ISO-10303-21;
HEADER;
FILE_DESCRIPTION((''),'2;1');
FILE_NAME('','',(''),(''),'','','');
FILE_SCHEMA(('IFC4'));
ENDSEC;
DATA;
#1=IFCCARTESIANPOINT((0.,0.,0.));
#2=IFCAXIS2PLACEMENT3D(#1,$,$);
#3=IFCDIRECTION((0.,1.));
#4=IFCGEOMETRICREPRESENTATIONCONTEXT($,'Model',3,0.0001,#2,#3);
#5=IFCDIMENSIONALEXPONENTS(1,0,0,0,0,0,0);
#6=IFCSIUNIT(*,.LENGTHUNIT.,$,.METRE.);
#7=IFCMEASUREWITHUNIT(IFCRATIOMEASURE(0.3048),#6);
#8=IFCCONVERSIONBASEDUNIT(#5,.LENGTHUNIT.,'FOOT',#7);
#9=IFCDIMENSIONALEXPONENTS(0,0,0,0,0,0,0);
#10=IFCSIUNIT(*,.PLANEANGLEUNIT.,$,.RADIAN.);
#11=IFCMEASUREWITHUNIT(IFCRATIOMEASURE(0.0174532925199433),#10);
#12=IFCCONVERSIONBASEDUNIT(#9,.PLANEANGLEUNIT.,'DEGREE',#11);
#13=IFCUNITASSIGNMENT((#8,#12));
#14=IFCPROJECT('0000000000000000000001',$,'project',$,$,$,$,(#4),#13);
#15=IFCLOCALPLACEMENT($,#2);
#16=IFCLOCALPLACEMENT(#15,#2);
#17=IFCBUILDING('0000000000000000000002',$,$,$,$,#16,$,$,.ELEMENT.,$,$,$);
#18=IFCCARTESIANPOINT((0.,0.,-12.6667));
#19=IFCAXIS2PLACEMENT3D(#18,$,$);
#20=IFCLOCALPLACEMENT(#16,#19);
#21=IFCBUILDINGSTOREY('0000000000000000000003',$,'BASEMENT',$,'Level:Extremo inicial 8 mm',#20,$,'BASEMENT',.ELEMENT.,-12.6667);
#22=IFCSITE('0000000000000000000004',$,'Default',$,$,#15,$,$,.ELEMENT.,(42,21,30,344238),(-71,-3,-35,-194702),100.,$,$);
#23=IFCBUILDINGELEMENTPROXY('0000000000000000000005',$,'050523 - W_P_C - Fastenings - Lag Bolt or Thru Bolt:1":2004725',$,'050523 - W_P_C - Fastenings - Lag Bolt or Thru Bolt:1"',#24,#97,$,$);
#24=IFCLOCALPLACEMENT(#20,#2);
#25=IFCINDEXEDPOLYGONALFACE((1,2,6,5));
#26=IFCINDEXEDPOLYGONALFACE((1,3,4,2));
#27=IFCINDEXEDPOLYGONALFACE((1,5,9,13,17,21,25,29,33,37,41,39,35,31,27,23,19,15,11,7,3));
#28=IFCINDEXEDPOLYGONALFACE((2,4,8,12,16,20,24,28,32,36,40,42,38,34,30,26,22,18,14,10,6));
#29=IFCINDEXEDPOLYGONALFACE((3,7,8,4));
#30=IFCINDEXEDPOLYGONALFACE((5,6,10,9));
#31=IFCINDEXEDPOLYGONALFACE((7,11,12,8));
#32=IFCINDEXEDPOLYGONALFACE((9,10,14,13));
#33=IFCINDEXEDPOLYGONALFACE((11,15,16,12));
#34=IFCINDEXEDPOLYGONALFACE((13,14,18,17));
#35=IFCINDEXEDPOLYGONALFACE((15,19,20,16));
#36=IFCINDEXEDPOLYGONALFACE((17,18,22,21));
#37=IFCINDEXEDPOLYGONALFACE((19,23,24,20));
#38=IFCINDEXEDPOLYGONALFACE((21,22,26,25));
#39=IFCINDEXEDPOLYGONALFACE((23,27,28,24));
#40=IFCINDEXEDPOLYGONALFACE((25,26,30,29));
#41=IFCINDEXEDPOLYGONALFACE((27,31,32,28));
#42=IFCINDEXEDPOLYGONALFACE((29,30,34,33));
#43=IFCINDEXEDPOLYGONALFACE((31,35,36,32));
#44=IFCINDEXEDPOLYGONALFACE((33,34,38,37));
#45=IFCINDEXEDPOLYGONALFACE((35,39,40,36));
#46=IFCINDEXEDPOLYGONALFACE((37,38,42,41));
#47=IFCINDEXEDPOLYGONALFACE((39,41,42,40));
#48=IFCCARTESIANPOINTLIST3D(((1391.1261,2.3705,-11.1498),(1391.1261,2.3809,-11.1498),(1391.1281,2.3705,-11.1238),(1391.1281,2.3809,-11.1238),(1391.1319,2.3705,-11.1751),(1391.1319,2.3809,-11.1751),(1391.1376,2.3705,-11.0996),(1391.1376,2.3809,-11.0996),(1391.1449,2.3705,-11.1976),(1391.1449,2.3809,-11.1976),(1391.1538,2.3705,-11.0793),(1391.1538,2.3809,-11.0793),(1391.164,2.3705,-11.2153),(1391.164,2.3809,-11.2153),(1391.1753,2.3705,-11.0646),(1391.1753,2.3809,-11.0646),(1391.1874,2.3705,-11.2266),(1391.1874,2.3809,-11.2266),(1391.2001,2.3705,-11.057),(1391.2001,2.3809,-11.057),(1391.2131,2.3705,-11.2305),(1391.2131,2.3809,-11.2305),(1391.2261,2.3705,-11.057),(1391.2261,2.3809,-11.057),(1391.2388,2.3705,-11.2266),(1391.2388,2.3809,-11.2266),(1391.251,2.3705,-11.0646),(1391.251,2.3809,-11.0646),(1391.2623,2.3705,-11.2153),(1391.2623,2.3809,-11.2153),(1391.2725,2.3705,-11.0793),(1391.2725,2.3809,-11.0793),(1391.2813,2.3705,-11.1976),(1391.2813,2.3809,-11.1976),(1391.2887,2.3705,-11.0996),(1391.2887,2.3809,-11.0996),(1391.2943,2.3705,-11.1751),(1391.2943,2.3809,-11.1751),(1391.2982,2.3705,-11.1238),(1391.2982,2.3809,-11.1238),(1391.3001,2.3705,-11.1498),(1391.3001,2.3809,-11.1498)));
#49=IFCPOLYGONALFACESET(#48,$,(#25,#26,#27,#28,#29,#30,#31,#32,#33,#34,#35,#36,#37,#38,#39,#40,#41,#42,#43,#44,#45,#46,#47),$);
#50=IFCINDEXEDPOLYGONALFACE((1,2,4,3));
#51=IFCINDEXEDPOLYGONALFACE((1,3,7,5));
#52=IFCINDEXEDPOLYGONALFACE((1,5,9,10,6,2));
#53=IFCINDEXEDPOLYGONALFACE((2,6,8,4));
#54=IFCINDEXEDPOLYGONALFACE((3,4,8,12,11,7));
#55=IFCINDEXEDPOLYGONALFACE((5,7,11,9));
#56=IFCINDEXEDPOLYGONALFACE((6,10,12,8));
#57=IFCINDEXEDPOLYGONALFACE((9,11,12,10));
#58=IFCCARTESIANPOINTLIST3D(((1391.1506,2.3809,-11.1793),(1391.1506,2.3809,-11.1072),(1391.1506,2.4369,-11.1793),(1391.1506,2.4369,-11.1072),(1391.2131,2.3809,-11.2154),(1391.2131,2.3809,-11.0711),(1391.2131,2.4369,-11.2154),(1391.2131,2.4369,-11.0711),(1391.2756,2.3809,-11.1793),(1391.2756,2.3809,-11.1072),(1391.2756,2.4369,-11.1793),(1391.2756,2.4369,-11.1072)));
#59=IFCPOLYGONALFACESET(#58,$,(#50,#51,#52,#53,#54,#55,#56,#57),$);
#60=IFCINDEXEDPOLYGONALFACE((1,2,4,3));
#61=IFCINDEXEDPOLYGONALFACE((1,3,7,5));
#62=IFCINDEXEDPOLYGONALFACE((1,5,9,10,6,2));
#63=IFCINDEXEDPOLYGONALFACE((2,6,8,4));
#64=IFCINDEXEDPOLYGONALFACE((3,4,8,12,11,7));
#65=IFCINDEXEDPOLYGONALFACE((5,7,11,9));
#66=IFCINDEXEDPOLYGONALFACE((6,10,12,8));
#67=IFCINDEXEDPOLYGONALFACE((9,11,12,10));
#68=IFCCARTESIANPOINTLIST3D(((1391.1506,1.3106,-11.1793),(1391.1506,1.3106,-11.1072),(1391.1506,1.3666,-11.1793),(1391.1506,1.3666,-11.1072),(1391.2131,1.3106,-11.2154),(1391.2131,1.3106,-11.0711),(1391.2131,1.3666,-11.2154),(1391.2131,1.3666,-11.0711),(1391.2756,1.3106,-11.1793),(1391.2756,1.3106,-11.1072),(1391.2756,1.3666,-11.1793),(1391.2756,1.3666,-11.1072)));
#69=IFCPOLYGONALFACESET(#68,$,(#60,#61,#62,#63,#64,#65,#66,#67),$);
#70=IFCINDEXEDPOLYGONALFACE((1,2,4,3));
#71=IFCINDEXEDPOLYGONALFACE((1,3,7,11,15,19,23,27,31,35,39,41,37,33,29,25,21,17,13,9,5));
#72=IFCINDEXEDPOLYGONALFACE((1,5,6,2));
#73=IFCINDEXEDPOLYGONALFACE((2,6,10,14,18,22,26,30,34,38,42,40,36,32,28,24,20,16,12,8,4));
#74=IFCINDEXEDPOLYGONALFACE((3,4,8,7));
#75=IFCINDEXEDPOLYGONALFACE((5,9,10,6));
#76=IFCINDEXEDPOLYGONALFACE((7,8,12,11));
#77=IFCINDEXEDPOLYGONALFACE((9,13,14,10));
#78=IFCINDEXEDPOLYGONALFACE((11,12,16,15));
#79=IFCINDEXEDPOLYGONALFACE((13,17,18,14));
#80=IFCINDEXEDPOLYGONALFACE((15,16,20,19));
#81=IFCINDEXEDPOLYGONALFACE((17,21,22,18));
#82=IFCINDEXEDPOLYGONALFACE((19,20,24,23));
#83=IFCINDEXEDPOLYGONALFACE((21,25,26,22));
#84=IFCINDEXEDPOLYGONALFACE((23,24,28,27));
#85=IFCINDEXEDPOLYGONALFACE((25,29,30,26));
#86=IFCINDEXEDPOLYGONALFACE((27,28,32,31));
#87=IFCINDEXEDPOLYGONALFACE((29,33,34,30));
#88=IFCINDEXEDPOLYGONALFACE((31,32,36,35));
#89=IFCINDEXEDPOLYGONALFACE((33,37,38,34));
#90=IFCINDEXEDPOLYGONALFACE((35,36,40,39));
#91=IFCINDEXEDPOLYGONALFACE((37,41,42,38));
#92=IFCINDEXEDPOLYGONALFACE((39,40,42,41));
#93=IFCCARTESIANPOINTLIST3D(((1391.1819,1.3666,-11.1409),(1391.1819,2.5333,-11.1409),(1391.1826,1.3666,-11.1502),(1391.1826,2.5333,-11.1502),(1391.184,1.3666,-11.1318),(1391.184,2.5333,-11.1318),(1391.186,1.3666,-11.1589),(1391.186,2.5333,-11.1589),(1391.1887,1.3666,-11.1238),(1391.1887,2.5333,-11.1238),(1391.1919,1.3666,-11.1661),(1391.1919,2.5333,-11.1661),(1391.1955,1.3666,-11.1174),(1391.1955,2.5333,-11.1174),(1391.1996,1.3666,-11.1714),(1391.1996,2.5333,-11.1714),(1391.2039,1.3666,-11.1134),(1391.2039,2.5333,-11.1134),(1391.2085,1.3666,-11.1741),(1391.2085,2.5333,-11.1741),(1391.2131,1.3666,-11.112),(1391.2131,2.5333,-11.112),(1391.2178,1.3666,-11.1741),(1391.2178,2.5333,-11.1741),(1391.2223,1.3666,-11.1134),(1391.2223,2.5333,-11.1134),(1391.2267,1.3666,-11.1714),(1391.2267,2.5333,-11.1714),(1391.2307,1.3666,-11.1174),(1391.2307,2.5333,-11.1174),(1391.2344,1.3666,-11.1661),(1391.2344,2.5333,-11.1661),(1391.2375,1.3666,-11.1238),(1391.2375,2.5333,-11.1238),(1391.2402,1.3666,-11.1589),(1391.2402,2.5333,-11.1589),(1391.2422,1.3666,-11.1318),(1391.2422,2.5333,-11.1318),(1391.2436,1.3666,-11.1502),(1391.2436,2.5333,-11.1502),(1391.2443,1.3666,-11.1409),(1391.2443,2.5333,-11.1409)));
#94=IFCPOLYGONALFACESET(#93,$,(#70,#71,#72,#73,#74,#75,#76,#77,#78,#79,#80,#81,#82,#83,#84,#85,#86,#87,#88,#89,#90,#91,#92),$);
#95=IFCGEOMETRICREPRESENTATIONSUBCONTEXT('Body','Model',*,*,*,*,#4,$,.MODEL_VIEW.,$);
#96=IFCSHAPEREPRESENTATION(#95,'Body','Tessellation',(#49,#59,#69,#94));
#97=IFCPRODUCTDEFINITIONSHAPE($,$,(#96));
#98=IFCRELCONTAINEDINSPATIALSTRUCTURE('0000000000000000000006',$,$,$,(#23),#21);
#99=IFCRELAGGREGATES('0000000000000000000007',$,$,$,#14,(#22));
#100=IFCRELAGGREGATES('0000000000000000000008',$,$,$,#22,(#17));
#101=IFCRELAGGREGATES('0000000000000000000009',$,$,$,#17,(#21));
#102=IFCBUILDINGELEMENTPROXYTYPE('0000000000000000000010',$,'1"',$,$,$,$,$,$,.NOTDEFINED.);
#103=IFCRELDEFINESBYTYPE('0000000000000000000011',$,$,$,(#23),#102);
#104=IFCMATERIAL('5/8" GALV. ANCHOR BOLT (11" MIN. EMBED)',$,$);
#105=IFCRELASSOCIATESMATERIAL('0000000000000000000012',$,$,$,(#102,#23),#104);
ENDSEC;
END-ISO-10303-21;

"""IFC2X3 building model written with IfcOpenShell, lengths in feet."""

from ifc_helpers import new_model, entity, si_unit, converted_unit, direction, frame, frame_2d, origin, place, context, subcontext, project, spatial, polyline, circle, outline, extrude, source, transform, mapped, material, type_object, type_shapes, element, save


model = new_model("IFC2X3")

# Units and contexts
model_context = context("Model", 3, precision=0.0001, world=origin(), true_north=direction((0.0, 1.0)))
body_context = subcontext(model_context, "Body", "Model", "MODEL_VIEW")
ifc_project = project(units=[converted_unit("LENGTHUNIT", "FOOT", entity("IfcRatioMeasure", 0.3048), si_unit("LENGTHUNIT", "METRE"), dimensions=[1, 0, 0, 0, 0, 0, 0]), converted_unit("PLANEANGLEUNIT", "DEGREE", entity("IfcRatioMeasure", 0.0174532925199433), si_unit("PLANEANGLEUNIT", "RADIAN"), dimensions=[0, 0, 0, 0, 0, 0, 0])], contexts=[model_context])

# Site, building, storey
site_placement = place(None, origin())
site = spatial("IfcSite", under=ifc_project, at=site_placement, Name="Default", CompositionType="ELEMENT", RefLatitude=(42, 21, 30, 344238), RefLongitude=(-71, -3, -35, -194702), RefElevation=100.0)
building_placement = place(site_placement, origin())
building = spatial("IfcBuilding", under=site, at=building_placement, CompositionType="ELEMENT")
storey_placement = place(building_placement, frame((0.0, 0.0, -12.6667)))
storey = spatial("IfcBuildingStorey", under=building, at=storey_placement, Name="BASEMENT", ObjectType="Level:Extremo inicial 8 mm", LongName="BASEMENT", CompositionType="ELEMENT", Elevation=-12.6667)

# Building element proxy
ifc_material_1 = material(Name="5/8\" GALV. ANCHOR BOLT (11\" MIN. EMBED)")
building_element_proxy_type_1 = type_object("IfcBuildingElementProxyType", Name="1\"", PredefinedType="NOTDEFINED", material=ifc_material_1)
shared_shape_1 = source(origin(), body_context, "Body", "SweptSolid", [
    extrude(circle(Radius=0.0872, at=frame_2d((0.0, 0.0), x_axis=(1.0, 0.0))), frame((0.0, 0.0, -1.0143), z_axis=(0.0, 0.0, 1.0), x_axis=(0.0, -1.0, 0.0)), (0.0, 0.0, 1.0), 0.0104),
    extrude(outline(polyline([(-0.0361, -0.0625), (0.0361, -0.0625), (0.0722, 0.0), (0.0361, 0.0625), (-0.0361, 0.0625), (-0.0722, 0.0), (-0.0361, -0.0625)])), frame((0.0, 0.0, -1.0703), z_axis=(0.0, 0.0, 1.0), x_axis=(0.866025, -0.5, 0.0)), (0.0, 0.0, 1.0), 0.056),
    extrude(outline(polyline([(-0.0361, -0.0625), (0.0361, -0.0625), (0.0722, 0.0), (0.0361, 0.0625), (-0.0361, 0.0625), (-0.0722, 0.0), (-0.0361, -0.0625)])), frame((0.0, 0.0, 0.0), z_axis=(0.0, 0.0, 1.0), x_axis=(0.0, -1.0, 0.0)), (0.0, 0.0, 1.0), 0.056),
    extrude(circle(Radius=0.0312, at=frame_2d((0.0, 0.0), x_axis=(1.0, 0.0))), frame((0.0, 0.0, -1.1667), z_axis=(0.0, 0.0, 1.0), x_axis=(0.0, 1.0, 0.0)), (0.0, 0.0, 1.0), 1.1667),
])
type_shapes(building_element_proxy_type_1, [shared_shape_1])
for number, where, z_axis, x_axis, name in (
    (1, (1391.2131, 1.3666, -11.1432), (0.0, -1.0, 0.0), (1.0, 0.0, 0.0), "050523 - W_P_C - Fastenings - Lag Bolt or Thru Bolt:1\":2004725"),
):
    element("IfcBuildingElementProxy", number, at=place(storey_placement, frame(where, z_axis=z_axis, x_axis=x_axis)), inside=storey, type_object=building_element_proxy_type_1, material=ifc_material_1, Name=name, ObjectType="050523 - W_P_C - Fastenings - Lag Bolt or Thru Bolt:1\"", context=body_context, shape_type="MappedRepresentation", body=[
        mapped(shared_shape_1, transform((0.0, 0.0, 0.0), scale=1.0)),
    ])

save(model, "model.ifc")
